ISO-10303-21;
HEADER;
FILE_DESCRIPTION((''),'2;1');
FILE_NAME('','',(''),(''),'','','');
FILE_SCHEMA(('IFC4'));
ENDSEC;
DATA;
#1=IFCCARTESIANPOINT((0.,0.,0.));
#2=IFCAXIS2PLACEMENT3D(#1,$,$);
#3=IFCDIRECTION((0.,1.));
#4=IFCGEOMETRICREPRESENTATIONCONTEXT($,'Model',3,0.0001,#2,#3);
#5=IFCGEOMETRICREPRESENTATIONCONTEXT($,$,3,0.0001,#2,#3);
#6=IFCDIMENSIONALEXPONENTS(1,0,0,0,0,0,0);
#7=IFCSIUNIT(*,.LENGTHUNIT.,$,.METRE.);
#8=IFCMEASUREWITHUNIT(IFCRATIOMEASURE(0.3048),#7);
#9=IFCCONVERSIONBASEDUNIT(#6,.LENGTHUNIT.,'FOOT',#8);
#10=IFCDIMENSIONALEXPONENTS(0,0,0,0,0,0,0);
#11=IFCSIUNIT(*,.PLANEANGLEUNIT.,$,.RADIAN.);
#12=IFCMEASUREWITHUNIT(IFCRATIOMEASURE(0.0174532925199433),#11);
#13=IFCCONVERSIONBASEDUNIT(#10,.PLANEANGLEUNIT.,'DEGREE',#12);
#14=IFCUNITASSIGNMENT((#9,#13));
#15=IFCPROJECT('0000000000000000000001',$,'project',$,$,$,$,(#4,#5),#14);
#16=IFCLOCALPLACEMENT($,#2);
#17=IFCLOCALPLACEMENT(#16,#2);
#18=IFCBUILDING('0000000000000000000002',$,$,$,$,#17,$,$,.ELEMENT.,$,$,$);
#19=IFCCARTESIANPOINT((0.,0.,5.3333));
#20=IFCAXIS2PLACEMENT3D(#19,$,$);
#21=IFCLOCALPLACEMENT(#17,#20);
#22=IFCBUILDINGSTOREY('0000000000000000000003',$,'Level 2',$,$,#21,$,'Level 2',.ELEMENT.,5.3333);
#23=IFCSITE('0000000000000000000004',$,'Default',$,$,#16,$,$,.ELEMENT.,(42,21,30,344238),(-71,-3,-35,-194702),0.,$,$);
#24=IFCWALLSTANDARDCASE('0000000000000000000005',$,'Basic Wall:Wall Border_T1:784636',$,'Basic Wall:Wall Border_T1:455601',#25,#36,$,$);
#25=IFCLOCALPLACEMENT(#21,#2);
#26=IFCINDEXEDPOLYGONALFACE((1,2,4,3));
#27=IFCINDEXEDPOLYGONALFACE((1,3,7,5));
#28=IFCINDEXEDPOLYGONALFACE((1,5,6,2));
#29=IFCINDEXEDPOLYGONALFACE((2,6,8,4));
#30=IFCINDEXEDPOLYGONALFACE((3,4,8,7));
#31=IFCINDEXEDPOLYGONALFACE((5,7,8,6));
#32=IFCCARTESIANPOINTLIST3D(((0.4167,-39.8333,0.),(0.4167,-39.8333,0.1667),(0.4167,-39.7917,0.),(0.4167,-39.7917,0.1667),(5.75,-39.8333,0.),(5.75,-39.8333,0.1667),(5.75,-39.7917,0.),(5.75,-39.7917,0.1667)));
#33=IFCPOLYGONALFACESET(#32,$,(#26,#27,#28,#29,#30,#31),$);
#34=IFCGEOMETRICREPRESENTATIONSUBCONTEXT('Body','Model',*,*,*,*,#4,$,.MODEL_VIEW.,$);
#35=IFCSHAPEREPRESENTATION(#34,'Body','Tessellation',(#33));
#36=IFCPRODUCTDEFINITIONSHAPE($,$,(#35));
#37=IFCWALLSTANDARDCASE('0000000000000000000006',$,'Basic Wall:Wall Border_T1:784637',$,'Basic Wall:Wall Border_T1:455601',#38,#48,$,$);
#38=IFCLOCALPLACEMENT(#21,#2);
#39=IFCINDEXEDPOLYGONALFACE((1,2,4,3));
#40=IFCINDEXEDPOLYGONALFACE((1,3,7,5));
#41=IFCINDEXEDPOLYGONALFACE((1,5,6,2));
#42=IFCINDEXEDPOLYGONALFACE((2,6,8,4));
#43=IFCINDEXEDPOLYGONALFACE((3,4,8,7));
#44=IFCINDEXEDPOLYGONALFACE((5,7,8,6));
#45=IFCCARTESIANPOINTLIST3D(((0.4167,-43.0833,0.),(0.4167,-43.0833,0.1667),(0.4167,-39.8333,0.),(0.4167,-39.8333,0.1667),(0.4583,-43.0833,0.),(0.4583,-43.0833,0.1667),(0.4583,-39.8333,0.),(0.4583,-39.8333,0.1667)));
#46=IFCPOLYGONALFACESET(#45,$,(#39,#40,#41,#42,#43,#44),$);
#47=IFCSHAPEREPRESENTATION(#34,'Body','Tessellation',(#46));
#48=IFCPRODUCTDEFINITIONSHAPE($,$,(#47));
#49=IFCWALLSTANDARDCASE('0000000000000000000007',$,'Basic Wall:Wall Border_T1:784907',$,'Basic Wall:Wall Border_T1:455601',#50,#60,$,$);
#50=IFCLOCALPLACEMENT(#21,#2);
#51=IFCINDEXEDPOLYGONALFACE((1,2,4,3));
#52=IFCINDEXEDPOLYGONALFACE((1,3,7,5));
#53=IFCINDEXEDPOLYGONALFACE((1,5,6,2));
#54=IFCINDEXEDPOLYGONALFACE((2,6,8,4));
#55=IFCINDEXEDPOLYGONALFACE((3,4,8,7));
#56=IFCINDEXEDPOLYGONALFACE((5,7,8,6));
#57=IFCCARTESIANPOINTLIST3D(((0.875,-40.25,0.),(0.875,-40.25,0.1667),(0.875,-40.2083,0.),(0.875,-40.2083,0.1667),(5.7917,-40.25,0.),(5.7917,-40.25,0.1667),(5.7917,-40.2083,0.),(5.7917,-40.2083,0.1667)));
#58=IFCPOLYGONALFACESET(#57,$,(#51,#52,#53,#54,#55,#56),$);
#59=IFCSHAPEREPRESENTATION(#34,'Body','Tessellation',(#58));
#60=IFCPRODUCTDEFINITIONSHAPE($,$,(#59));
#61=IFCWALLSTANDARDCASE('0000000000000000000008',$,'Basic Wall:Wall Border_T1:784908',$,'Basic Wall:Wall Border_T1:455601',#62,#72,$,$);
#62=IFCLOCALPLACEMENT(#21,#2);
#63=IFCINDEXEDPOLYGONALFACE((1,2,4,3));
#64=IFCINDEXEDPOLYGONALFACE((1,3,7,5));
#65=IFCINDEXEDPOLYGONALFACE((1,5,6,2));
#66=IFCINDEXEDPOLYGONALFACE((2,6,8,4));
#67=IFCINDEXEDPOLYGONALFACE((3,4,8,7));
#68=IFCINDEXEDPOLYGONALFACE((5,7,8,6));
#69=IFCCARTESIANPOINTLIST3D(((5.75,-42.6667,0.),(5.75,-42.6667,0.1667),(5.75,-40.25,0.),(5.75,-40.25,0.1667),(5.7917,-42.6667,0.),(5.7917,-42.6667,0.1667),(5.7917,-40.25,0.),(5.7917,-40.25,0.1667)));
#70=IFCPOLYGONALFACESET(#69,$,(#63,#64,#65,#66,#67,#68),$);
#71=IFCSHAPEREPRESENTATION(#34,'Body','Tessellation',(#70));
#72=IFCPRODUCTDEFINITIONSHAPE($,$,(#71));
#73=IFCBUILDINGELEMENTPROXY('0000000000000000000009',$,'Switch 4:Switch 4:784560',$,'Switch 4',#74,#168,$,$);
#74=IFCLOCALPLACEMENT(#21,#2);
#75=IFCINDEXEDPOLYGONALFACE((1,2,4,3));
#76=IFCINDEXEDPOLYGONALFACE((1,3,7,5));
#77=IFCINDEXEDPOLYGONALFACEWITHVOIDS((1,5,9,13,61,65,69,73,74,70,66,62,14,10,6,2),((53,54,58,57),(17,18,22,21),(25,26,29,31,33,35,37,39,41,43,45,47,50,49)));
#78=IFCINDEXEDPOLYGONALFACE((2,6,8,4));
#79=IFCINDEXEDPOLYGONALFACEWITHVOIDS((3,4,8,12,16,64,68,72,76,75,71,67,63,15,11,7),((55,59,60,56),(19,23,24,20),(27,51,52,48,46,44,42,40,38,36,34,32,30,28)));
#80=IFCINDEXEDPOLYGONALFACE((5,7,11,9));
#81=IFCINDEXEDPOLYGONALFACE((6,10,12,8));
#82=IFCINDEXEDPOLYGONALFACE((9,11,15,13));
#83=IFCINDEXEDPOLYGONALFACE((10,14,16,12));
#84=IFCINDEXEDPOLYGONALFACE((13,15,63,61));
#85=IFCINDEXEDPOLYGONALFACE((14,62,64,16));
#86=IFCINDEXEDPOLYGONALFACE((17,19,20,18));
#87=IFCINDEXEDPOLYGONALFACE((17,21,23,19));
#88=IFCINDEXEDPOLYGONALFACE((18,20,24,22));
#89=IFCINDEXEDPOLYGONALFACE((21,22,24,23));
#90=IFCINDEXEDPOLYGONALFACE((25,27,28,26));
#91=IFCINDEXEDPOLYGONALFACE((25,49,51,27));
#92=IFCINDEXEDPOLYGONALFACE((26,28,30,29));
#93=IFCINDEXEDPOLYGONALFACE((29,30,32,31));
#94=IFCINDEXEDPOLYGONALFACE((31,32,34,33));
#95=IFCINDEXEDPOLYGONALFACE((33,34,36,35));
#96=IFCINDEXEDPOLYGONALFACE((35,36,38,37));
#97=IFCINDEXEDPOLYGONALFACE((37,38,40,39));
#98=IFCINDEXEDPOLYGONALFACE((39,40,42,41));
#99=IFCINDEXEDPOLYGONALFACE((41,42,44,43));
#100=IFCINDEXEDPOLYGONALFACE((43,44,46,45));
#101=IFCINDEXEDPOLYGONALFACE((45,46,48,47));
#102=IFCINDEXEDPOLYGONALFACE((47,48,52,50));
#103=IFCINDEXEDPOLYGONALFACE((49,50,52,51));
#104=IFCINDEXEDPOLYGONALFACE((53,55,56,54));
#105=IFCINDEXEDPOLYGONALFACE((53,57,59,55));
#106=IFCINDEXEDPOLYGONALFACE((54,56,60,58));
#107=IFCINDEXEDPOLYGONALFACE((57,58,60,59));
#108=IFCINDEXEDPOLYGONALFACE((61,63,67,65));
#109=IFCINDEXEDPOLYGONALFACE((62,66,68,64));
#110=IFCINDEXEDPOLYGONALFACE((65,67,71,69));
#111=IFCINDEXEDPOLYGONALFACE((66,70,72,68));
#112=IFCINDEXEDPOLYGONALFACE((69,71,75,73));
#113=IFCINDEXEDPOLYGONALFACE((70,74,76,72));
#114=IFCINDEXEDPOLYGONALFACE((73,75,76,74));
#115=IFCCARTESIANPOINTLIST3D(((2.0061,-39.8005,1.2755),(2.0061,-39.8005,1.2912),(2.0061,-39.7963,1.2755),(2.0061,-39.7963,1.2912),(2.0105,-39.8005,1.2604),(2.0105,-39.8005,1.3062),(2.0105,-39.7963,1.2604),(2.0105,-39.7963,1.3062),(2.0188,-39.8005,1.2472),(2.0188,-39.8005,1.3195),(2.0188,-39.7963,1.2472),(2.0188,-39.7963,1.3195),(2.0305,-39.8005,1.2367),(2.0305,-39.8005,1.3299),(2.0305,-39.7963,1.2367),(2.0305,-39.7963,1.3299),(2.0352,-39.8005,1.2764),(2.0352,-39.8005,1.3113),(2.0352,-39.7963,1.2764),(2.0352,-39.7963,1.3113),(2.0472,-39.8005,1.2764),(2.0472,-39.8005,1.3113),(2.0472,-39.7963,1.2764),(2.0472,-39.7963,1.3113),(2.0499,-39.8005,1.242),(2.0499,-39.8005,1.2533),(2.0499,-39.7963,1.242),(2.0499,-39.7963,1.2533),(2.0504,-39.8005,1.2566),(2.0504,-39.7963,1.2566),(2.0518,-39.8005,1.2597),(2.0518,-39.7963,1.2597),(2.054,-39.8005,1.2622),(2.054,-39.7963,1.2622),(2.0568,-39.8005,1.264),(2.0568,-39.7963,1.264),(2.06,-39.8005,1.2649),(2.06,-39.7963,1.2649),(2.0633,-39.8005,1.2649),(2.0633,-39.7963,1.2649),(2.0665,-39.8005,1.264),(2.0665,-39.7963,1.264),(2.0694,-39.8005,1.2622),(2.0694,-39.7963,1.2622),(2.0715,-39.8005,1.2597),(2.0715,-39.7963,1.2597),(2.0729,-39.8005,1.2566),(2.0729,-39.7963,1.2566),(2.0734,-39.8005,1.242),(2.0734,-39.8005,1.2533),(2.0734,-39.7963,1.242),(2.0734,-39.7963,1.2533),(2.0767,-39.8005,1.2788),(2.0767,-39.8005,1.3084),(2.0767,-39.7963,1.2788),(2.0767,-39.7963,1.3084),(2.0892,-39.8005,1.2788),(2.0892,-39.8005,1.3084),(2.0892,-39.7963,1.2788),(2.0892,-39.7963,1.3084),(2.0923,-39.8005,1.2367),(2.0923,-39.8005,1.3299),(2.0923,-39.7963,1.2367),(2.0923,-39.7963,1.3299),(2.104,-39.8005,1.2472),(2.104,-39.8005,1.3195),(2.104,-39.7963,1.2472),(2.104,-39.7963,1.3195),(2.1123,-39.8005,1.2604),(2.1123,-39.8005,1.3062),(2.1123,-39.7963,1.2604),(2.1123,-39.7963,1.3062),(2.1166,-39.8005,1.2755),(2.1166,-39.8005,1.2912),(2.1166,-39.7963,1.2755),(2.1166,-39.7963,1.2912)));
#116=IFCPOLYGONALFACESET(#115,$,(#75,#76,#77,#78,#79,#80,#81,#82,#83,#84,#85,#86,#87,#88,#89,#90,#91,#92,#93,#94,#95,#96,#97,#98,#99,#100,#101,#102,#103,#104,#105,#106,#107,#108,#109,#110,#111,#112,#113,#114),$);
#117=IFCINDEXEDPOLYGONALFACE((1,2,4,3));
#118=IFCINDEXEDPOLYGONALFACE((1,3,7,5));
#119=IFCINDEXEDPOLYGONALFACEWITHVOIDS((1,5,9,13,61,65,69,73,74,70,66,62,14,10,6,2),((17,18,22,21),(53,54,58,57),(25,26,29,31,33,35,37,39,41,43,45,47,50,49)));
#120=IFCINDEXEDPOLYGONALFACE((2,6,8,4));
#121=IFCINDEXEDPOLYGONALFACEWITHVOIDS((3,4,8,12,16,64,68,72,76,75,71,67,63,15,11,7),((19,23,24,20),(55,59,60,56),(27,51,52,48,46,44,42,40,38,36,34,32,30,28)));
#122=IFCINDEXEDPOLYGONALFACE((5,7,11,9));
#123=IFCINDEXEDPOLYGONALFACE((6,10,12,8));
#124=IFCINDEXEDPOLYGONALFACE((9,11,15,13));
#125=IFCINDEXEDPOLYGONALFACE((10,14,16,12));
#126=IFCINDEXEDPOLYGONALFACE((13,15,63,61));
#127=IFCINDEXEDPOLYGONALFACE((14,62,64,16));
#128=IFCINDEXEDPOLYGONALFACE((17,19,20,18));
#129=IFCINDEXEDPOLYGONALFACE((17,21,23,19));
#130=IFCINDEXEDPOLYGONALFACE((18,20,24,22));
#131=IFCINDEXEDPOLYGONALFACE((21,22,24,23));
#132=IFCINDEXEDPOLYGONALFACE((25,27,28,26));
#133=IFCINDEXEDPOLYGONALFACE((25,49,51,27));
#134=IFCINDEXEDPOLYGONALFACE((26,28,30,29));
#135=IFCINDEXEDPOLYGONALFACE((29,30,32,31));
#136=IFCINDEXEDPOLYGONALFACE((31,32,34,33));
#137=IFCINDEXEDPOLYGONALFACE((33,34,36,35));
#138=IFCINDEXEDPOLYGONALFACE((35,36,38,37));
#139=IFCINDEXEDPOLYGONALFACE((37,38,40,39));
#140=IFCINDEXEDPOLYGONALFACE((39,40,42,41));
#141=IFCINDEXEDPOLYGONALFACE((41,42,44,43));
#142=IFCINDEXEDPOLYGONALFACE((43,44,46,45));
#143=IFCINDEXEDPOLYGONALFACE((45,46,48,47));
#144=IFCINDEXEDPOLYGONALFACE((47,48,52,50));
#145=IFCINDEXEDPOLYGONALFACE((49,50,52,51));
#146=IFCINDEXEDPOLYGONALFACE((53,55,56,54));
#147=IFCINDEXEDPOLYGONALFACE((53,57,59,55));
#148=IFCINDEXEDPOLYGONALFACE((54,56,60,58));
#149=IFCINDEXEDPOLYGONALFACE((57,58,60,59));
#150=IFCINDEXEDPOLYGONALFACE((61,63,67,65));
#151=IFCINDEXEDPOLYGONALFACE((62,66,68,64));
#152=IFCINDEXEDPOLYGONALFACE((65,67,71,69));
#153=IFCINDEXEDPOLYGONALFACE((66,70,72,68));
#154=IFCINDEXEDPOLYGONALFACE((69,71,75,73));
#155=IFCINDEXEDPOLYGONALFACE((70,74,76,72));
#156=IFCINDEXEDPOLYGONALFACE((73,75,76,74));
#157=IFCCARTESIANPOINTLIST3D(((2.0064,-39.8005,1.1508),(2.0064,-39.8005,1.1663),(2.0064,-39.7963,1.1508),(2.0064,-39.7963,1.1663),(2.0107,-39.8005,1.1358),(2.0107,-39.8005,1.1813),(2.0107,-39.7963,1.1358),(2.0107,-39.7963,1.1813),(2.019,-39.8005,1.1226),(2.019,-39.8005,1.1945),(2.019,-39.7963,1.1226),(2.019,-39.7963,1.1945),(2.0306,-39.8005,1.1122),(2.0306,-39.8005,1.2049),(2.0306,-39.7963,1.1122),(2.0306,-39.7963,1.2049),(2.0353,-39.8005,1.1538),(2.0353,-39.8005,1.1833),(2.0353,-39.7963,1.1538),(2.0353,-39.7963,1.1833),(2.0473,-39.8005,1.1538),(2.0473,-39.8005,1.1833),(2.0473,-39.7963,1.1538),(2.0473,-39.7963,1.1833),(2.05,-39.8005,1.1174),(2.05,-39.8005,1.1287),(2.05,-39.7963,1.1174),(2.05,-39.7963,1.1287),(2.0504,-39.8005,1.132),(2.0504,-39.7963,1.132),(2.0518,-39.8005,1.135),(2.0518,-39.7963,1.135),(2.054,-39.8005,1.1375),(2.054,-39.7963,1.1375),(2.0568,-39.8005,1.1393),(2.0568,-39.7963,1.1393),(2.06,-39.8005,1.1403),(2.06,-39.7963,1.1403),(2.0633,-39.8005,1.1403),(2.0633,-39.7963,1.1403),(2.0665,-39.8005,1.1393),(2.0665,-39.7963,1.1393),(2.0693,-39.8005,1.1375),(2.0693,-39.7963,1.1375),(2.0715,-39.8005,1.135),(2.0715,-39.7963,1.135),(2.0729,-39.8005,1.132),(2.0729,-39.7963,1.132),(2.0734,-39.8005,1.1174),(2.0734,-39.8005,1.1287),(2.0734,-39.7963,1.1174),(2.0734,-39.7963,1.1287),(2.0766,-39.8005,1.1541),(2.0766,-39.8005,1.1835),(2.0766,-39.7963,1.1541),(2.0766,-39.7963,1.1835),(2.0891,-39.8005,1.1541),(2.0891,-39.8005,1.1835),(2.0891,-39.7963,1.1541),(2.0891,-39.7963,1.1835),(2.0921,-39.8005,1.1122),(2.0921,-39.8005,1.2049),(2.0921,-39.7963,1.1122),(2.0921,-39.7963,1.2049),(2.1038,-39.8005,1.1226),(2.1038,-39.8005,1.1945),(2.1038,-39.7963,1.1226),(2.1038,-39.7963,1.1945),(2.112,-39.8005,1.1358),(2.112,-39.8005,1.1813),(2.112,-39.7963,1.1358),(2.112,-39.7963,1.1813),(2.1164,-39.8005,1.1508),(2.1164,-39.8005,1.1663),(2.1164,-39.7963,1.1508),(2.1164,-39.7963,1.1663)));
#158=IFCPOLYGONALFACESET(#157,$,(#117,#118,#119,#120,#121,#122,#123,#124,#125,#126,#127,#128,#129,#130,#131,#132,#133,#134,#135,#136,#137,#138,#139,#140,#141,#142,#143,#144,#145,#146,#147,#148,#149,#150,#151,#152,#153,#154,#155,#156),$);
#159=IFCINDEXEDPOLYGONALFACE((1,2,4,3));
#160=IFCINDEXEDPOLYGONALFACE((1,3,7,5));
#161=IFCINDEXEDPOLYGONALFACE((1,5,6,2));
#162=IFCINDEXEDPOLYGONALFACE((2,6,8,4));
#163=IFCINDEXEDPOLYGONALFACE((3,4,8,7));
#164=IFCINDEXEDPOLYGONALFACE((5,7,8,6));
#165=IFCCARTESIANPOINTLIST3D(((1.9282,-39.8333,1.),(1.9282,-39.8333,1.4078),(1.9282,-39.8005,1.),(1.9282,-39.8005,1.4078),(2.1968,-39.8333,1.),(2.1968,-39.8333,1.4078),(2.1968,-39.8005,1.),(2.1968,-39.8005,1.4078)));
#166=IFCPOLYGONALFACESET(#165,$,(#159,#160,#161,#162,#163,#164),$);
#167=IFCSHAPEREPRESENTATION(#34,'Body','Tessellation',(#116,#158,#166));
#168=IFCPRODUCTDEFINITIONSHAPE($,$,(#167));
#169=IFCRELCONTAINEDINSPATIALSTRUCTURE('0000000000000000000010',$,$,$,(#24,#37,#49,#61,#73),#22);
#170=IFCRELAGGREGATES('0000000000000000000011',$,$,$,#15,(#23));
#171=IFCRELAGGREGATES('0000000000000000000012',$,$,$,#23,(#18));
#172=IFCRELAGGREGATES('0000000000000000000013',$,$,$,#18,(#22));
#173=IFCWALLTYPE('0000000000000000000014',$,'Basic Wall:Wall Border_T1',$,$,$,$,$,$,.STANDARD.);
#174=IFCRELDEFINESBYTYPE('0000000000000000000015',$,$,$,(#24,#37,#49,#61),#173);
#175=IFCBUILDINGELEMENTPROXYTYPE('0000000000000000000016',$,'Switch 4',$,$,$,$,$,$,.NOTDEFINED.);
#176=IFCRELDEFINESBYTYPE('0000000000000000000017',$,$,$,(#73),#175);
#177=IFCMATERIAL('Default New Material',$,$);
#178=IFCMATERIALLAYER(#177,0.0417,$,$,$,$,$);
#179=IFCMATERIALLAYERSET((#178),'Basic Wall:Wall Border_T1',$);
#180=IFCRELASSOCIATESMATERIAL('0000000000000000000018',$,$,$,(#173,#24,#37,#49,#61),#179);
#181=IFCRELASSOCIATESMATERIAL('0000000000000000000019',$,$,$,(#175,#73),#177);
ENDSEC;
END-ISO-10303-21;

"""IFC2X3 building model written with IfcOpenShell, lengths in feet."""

from ifc_helpers import new_model, entity, si_unit, converted_unit, direction, frame, frame_2d, origin, origin_2d_with_axis, place, context, subcontext, project, spatial, polyline, circle_curve, parameter, trimmed, segment, composite_curve, rectangle, outline, extrude, source, transform, mapped, material, layer, layer_set, layer_usage, type_object, type_shapes, element, save


model = new_model("IFC2X3")

# Units and contexts
model_context = context("Model", 3, precision=0.0001, world=origin(), true_north=direction((0.0, 1.0)))
context_of_model = context(None, 3, precision=0.0001, world=origin(), true_north=direction((0.0, 1.0)))
body_context = subcontext(model_context, "Body", "Model", "MODEL_VIEW")
ifc_project = project(units=[converted_unit("LENGTHUNIT", "FOOT", entity("IfcRatioMeasure", 0.3048), si_unit("LENGTHUNIT", "METRE"), dimensions=[1, 0, 0, 0, 0, 0, 0]), converted_unit("PLANEANGLEUNIT", "DEGREE", entity("IfcRatioMeasure", 0.0174532925199433), si_unit("PLANEANGLEUNIT", "RADIAN"), dimensions=[0, 0, 0, 0, 0, 0, 0])], contexts=[model_context, context_of_model])

# Site, building, storey
site_placement = place(None, origin())
site = spatial("IfcSite", under=ifc_project, at=site_placement, Name="Default", CompositionType="ELEMENT", RefLatitude=(42, 21, 30, 344238), RefLongitude=(-71, -3, -35, -194702), RefElevation=0.0)
building_placement = place(site_placement, origin())
building = spatial("IfcBuilding", under=site, at=building_placement, CompositionType="ELEMENT")
storey_placement = place(building_placement, frame((0.0, 0.0, 5.3333)))
storey = spatial("IfcBuildingStorey", under=building, at=storey_placement, Name="Level 2", LongName="Level 2", CompositionType="ELEMENT", Elevation=5.3333)

# Shared definitions
ifc_material = material(Name="Default New Material")

# Walls
ifc_layer_1 = layer(ifc_material, 0.0417)
ifc_layer_set_1 = layer_set([ifc_layer_1], Name="Basic Wall:Wall Border_T1")
wall_type_1 = type_object("IfcWallType", Name="Basic Wall:Wall Border_T1", PredefinedType="STANDARD", material=ifc_layer_set_1)
ifc_layer_usage_1 = layer_usage(ifc_layer_set_1, "AXIS2", "POSITIVE", -0.0208)
wall_1_placement = place(storey_placement, frame((5.75, -39.8125, 0.0), z_axis=(0.0, 0.0, 1.0), x_axis=(-1.0, 0.0, 0.0)))
element("IfcWallStandardCase", 1, at=wall_1_placement, inside=storey, type_object=wall_type_1, material=ifc_layer_usage_1, Name="Basic Wall:Wall Border_T1:784636", ObjectType="Basic Wall:Wall Border_T1:455601", context=body_context, shape_type="SweptSolid", body=[
    extrude(rectangle(XDim=5.3333, YDim=0.0417, at=frame_2d((2.6667, 0.0), x_axis=(-1.0, 0.0))), origin(), (0.0, 0.0, 1.0), 0.1667),
])
ifc_layer_usage_2 = layer_usage(ifc_layer_set_1, "AXIS2", "POSITIVE", -0.0208)
wall_2_placement = place(storey_placement, frame((0.4375, -39.8333, 0.0), z_axis=(0.0, 0.0, 1.0), x_axis=(0.0, -1.0, 0.0)))
element("IfcWallStandardCase", 2, at=wall_2_placement, inside=storey, type_object=wall_type_1, material=ifc_layer_usage_2, Name="Basic Wall:Wall Border_T1:784637", ObjectType="Basic Wall:Wall Border_T1:455601", context=body_context, shape_type="SweptSolid", body=[
    extrude(rectangle(XDim=3.25, YDim=0.0417, at=frame_2d((1.625, 0.0), x_axis=(-1.0, 0.0))), origin(), (0.0, 0.0, 1.0), 0.1667),
])
ifc_layer_usage_3 = layer_usage(ifc_layer_set_1, "AXIS2", "POSITIVE", -0.0208)
wall_3_placement = place(storey_placement, frame((0.875, -40.2292, 0.0)))
element("IfcWallStandardCase", 3, at=wall_3_placement, inside=storey, type_object=wall_type_1, material=ifc_layer_usage_3, Name="Basic Wall:Wall Border_T1:784907", ObjectType="Basic Wall:Wall Border_T1:455601", context=body_context, shape_type="SweptSolid", body=[
    extrude(rectangle(XDim=4.9167, YDim=0.0417, at=frame_2d((2.4583, 0.0), x_axis=(-1.0, 0.0))), origin(), (0.0, 0.0, 1.0), 0.1667),
])
ifc_layer_usage_4 = layer_usage(ifc_layer_set_1, "AXIS2", "POSITIVE", -0.0208)
wall_4_placement = place(storey_placement, frame((5.7708, -40.25, 0.0), z_axis=(0.0, 0.0, 1.0), x_axis=(0.0, -1.0, 0.0)))
element("IfcWallStandardCase", 4, at=wall_4_placement, inside=storey, type_object=wall_type_1, material=ifc_layer_usage_4, Name="Basic Wall:Wall Border_T1:784908", ObjectType="Basic Wall:Wall Border_T1:455601", context=body_context, shape_type="SweptSolid", body=[
    extrude(rectangle(XDim=2.4167, YDim=0.0417, at=frame_2d((1.2083, 0.0), x_axis=(-1.0, 0.0))), origin(), (0.0, 0.0, 1.0), 0.1667),
])

# Building element proxy
building_element_proxy_type_1 = type_object("IfcBuildingElementProxyType", Name="Switch 4", PredefinedType="NOTDEFINED", material=ifc_material)
shared_shape_1 = source(origin(), body_context, "Body", "SweptSolid", [
    extrude(outline(composite_curve([segment(polyline([(-0.0309, -0.0466), (0.0309, -0.0466)]), True, "CONTINUOUS"), segment(trimmed(circle_curve(frame_2d((-0.0003, 0.0), x_axis=(-1.0, 0.0)), 0.0561), [parameter(123.794741)], [parameter(236.205259)], True, "PARAMETER"), True, "CONTINUOUS"), segment(polyline([(0.0309, 0.0466), (-0.0309, 0.0466)]), True, "CONTINUOUS"), segment(trimmed(circle_curve(frame_2d((0.0003, 0.0), x_axis=(1.0, 0.0)), 0.0561), [parameter(123.794741)], [parameter(236.205259)], True, "PARAMETER"), True, "CONTINUOUS")], self_intersect=False), holes=[polyline([(0.0142, 0.0279), (0.0262, 0.0279), (0.0262, -0.0069), (0.0142, -0.0069), (0.0142, 0.0279)]), polyline([(-0.0153, 0.025), (-0.0153, -0.0045), (-0.0278, -0.0045), (-0.0278, 0.025), (-0.0153, 0.025)]), composite_curve([segment(polyline([(-0.012, -0.0413), (-0.012, -0.03)]), True, "CONTINUOUS"), segment(trimmed(circle_curve(frame_2d((-0.0003, -0.03), x_axis=(-1.0, 0.0)), 0.0117), [parameter(180.0)], [parameter(0.0)], True, "PARAMETER"), False, "CONTINUOUS"), segment(polyline([(0.0115, -0.03), (0.0115, -0.0413)]), True, "CONTINUOUS"), segment(polyline([(0.0115, -0.0413), (-0.012, -0.0413)]), True, "CONTINUOUS")], self_intersect=False)]), frame((-0.0011, 0.0328, 0.2833), z_axis=(0.0, 1.0, 0.0), x_axis=(-1.0, 0.0, 0.0)), (0.0, 0.0, 1.0), 0.0042),
    extrude(outline(composite_curve([segment(polyline([(-0.0308, -0.0464), (0.0308, -0.0464)]), True, "CONTINUOUS"), segment(trimmed(circle_curve(frame_2d((-0.0003, 0.0), x_axis=(-1.0, 0.0)), 0.0558), [parameter(123.794741)], [parameter(236.205259)], True, "PARAMETER"), True, "CONTINUOUS"), segment(polyline([(0.0308, 0.0464), (-0.0308, 0.0464)]), True, "CONTINUOUS"), segment(trimmed(circle_curve(frame_2d((0.0003, 0.0), x_axis=(1.0, 0.0)), 0.0558), [parameter(123.794741)], [parameter(236.205259)], True, "PARAMETER"), True, "CONTINUOUS")], self_intersect=False), holes=[polyline([(0.0141, 0.0247), (0.026, 0.0247), (0.026, -0.0047), (0.0141, -0.0047), (0.0141, 0.0247)]), polyline([(-0.0152, 0.0249), (-0.0152, -0.0045), (-0.0277, -0.0045), (-0.0277, 0.0249), (-0.0152, 0.0249)]), composite_curve([segment(polyline([(-0.012, -0.0411), (-0.012, -0.0299)]), True, "CONTINUOUS"), segment(trimmed(circle_curve(frame_2d((-0.0003, -0.0299), x_axis=(-1.0, 0.0)), 0.0117), [parameter(180.0)], [parameter(0.0)], True, "PARAMETER"), False, "CONTINUOUS"), segment(polyline([(0.0114, -0.0299), (0.0114, -0.0411)]), True, "CONTINUOUS"), segment(polyline([(0.0114, -0.0411), (-0.012, -0.0411)]), True, "CONTINUOUS")], self_intersect=False)]), frame((-0.0011, 0.0328, 0.1586), z_axis=(0.0, 1.0, 0.0), x_axis=(-1.0, 0.0, 0.0)), (0.0, 0.0, 1.0), 0.0042),
    extrude(rectangle(XDim=0.0328, YDim=0.2687, at=origin_2d_with_axis()), frame((0.0, 0.0164, 0.0), z_axis=(0.0, 0.0, 1.0), x_axis=(0.0, -1.0, 0.0)), (0.0, 0.0, 1.0), 0.4078),
])
type_shapes(building_element_proxy_type_1, [shared_shape_1])
proxy_1_placement = place(storey_placement, frame((2.0625, -39.8333, 1.0)))
element("IfcBuildingElementProxy", 5, at=proxy_1_placement, inside=storey, type_object=building_element_proxy_type_1, material=ifc_material, Name="Switch 4:Switch 4:784560", ObjectType="Switch 4", context=body_context, shape_type="MappedRepresentation", body=[
    mapped(shared_shape_1, transform((0.0, 0.0, 0.0), scale=1.0)),
])

save(model, "model.ifc")
